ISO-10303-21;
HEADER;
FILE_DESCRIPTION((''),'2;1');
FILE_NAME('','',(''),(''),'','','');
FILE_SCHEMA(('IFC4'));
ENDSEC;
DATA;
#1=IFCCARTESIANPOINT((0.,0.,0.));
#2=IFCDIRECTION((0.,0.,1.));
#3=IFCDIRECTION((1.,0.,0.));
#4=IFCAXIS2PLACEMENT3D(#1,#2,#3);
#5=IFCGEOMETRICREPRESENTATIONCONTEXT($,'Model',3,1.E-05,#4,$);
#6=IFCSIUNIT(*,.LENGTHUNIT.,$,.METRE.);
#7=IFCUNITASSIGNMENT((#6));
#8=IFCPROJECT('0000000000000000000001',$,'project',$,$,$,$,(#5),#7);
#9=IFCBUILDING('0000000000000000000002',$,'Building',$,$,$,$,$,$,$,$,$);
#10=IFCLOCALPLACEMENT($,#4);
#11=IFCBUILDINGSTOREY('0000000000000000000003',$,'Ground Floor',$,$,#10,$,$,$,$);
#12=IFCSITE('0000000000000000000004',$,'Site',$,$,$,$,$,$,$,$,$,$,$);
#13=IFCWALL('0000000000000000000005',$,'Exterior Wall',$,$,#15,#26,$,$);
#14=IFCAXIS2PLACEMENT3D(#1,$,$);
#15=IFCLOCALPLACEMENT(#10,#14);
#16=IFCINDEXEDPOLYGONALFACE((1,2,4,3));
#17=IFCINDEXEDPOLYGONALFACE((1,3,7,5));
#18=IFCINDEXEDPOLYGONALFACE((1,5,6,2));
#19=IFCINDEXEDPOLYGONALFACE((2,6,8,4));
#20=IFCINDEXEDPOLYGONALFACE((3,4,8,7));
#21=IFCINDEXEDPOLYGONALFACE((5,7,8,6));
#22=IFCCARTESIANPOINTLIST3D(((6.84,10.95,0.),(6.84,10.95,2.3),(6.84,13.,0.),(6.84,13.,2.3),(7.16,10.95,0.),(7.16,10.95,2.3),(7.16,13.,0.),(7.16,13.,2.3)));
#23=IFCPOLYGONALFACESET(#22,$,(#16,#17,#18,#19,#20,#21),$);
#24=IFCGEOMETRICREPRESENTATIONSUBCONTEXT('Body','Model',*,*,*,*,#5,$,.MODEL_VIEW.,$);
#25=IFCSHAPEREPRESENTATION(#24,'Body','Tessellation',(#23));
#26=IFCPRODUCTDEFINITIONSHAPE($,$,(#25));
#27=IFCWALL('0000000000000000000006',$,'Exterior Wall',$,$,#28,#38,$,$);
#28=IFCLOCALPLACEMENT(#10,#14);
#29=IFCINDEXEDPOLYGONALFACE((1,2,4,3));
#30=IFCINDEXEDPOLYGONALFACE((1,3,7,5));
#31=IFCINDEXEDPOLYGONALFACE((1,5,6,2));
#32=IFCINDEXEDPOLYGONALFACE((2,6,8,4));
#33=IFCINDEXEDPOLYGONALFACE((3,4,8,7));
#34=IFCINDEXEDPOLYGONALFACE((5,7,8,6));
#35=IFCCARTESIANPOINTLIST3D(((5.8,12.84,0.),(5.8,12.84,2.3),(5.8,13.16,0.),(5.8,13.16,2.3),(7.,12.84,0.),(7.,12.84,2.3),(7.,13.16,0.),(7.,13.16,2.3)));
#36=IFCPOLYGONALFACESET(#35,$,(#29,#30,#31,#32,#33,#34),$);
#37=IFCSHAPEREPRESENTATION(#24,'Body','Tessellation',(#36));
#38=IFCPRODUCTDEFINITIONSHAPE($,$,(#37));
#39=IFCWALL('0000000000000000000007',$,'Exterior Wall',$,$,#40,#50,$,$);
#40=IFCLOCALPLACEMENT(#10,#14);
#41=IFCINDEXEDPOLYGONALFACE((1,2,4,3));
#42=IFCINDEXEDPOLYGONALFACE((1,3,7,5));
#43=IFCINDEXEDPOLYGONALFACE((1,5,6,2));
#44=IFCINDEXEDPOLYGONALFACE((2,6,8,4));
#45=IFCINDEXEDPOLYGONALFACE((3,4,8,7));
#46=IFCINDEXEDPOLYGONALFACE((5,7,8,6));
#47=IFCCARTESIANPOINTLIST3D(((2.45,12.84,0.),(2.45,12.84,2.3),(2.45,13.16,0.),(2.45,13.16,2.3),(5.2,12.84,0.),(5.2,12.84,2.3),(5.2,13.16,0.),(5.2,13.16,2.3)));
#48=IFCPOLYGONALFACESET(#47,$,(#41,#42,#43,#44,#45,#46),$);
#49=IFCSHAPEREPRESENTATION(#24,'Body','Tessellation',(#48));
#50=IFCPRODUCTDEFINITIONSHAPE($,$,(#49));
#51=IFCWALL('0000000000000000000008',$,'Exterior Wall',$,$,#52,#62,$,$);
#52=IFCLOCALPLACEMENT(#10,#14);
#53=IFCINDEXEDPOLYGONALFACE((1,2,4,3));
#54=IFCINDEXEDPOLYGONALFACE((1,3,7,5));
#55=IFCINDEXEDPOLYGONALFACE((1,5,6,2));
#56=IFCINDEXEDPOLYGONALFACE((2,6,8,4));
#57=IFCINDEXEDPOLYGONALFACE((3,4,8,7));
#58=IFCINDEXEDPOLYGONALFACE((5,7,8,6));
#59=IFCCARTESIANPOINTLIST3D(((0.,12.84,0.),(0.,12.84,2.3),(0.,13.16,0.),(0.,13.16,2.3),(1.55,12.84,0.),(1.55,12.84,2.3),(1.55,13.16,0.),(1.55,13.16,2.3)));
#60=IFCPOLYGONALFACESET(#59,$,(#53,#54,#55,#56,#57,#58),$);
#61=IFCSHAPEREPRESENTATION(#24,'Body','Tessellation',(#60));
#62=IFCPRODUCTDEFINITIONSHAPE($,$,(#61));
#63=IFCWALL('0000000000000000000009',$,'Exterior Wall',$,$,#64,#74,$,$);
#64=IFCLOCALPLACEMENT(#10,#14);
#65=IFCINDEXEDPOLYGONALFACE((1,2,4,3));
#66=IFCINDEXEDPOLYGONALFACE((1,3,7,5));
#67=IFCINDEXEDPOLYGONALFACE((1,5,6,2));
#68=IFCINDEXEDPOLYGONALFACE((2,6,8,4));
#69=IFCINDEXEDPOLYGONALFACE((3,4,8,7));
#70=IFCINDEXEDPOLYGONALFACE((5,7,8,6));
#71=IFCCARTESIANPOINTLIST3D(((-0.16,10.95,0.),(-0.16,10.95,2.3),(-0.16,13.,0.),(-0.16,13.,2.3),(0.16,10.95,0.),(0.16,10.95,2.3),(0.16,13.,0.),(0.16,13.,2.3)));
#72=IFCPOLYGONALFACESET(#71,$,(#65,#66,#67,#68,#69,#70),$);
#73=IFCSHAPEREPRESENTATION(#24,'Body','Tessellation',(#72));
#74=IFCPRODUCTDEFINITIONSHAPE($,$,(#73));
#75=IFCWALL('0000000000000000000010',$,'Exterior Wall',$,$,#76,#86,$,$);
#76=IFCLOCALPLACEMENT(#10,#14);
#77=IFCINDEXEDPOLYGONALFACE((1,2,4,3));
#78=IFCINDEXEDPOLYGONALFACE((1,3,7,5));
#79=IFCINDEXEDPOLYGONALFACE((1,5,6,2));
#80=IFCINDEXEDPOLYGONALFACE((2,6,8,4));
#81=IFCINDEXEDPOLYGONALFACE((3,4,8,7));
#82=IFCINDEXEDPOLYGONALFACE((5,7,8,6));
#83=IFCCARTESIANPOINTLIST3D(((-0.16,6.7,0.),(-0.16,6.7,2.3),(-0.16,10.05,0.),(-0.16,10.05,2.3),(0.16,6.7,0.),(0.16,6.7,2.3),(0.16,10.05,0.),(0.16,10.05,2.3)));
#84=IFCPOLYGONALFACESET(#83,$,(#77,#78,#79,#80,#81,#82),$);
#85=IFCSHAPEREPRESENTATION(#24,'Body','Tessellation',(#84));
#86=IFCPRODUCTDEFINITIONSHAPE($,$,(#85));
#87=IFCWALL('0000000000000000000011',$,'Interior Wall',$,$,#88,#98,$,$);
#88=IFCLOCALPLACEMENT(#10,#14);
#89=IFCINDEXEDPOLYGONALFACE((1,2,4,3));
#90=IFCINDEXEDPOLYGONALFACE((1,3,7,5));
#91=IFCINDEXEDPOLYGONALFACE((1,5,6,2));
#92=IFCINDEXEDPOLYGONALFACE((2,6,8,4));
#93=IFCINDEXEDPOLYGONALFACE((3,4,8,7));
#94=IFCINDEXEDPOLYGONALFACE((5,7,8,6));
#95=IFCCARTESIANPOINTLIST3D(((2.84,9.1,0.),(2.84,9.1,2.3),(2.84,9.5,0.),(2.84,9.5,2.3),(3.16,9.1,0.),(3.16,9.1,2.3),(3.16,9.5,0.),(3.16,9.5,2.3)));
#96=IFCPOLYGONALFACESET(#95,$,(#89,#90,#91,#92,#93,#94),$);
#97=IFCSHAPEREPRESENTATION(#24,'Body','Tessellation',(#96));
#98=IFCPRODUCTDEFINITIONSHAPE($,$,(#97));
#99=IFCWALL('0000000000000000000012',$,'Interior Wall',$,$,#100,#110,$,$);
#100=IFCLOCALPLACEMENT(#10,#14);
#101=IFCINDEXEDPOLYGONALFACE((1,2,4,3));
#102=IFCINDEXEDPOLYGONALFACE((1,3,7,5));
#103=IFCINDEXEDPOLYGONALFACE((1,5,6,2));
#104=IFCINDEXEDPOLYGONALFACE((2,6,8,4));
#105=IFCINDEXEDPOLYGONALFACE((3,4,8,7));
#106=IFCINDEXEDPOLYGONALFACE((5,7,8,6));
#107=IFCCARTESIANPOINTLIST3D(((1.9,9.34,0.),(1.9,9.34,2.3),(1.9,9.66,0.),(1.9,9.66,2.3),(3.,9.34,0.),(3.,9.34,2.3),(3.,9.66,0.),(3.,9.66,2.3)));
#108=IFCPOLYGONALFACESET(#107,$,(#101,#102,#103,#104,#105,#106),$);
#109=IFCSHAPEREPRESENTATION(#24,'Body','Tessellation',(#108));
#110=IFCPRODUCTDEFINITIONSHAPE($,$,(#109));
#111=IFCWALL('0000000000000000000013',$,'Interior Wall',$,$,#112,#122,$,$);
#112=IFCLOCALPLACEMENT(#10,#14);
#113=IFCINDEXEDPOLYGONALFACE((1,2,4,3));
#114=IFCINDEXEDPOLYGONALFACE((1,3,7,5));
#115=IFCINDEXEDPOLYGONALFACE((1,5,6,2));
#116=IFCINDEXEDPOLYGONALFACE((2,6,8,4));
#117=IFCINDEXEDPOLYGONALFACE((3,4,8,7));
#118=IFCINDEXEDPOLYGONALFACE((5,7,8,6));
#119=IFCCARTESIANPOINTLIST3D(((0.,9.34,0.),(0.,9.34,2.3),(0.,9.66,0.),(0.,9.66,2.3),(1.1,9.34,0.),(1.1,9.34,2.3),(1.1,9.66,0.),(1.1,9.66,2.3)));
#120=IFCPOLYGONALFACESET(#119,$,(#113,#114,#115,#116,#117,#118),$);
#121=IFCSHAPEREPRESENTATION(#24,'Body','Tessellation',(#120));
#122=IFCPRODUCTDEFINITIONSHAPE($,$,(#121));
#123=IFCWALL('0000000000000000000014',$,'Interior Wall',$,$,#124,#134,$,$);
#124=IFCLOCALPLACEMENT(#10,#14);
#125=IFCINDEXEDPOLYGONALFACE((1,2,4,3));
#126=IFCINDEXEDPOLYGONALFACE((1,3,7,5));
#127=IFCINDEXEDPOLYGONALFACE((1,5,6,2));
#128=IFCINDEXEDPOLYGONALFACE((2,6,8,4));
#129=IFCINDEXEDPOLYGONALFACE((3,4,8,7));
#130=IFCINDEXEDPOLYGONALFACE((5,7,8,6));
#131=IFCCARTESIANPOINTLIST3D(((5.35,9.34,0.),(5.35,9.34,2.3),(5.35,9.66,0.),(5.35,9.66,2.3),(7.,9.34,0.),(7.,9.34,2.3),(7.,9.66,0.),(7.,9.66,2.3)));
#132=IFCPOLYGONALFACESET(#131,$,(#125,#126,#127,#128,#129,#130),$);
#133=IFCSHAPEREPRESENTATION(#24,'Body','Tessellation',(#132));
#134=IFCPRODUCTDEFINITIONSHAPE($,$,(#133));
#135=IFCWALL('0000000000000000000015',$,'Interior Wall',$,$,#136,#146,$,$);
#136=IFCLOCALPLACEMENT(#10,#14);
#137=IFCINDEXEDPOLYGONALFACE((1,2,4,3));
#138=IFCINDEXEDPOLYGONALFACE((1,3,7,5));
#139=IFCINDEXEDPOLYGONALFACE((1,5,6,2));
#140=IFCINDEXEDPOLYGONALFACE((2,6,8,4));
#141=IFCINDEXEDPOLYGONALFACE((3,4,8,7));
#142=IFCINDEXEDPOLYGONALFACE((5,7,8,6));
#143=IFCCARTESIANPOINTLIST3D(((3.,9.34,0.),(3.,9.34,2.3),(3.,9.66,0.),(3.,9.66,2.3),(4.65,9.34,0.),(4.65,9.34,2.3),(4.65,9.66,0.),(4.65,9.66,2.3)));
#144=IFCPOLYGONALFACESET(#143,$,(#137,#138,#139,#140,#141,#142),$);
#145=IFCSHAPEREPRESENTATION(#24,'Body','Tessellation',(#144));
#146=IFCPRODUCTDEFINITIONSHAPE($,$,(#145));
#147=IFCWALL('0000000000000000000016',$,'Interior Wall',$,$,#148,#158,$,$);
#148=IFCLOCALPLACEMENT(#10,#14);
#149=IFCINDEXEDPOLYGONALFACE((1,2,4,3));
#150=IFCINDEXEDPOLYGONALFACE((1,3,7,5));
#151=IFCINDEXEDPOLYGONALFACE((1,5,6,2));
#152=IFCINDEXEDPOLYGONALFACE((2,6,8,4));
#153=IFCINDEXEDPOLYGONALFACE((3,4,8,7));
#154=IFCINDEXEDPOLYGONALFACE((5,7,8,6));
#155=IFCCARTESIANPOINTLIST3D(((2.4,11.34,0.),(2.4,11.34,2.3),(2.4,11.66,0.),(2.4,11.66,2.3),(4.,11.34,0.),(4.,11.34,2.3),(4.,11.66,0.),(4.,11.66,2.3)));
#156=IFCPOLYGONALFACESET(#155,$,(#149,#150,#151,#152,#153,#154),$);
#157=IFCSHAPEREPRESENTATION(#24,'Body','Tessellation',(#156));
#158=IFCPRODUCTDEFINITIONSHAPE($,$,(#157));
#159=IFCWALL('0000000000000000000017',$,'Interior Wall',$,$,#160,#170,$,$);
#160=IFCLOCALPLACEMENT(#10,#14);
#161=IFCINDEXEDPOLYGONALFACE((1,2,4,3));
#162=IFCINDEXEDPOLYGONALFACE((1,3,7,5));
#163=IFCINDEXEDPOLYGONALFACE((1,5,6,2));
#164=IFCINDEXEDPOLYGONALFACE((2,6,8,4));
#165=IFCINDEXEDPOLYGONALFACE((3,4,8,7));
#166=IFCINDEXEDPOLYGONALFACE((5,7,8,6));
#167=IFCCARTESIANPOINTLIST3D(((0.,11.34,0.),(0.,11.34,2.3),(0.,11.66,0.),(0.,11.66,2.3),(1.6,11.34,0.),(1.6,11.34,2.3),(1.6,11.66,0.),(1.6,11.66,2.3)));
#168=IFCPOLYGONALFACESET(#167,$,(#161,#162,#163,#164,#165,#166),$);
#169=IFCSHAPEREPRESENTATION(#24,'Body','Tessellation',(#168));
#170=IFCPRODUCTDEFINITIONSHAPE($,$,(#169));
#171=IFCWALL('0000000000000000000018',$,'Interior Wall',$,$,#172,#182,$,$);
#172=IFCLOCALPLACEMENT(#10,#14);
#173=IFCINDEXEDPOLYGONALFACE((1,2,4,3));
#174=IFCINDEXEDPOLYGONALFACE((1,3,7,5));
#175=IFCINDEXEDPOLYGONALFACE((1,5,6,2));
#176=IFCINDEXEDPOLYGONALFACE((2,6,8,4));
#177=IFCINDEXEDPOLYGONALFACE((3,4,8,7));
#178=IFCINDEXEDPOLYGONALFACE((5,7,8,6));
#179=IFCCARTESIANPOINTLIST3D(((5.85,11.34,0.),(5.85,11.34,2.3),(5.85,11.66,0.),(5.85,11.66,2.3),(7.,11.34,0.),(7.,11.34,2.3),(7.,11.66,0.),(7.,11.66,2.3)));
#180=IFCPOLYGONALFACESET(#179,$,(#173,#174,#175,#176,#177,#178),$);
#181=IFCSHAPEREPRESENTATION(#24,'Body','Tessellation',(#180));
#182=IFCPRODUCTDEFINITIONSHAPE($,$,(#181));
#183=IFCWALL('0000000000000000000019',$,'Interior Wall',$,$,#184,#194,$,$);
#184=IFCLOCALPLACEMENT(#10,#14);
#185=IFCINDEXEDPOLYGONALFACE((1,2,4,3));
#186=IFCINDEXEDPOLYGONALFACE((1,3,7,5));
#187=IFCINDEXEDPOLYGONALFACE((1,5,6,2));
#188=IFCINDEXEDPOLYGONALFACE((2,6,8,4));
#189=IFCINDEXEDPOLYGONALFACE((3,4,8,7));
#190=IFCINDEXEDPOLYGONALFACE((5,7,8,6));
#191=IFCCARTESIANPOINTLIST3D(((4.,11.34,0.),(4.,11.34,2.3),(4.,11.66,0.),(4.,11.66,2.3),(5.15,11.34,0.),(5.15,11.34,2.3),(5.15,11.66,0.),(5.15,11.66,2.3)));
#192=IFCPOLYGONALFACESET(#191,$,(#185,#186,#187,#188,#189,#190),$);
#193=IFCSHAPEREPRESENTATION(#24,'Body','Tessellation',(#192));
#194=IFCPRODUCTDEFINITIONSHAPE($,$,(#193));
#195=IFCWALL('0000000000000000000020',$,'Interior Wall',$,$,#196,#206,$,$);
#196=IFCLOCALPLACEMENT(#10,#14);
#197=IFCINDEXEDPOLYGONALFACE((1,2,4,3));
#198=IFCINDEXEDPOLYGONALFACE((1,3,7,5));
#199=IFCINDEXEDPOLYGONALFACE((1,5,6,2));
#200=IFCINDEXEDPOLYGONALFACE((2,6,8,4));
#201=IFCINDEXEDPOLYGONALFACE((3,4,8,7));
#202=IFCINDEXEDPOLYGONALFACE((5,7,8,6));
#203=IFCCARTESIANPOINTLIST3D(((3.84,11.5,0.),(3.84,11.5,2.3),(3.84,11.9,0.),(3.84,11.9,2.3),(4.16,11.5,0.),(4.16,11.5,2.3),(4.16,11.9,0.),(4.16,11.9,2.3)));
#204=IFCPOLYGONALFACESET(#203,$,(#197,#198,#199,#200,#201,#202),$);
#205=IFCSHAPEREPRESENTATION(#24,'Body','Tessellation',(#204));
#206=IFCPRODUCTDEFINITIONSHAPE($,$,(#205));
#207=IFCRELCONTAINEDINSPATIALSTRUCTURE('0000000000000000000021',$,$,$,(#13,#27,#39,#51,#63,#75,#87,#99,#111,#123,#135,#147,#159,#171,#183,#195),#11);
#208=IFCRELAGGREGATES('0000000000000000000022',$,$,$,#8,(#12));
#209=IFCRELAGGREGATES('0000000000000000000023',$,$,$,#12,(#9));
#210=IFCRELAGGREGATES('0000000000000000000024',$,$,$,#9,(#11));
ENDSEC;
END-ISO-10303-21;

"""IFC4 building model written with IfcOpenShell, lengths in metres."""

from ifc_helpers import new_model, si_unit, frame, origin_with_axes, place, context, subcontext, project, spatial, indexed_curve, outline, extrude, element, save


model = new_model("IFC4")

# Units and contexts
model_context = context("Model", 3, precision=1e-05, world=origin_with_axes())
body_context = subcontext(model_context, "Body", "Model", "MODEL_VIEW")
ifc_project = project(units=[si_unit("LENGTHUNIT", "METRE")], contexts=[model_context])

# Site, building, storey
site = spatial("IfcSite", under=ifc_project, Name="Site")
building = spatial("IfcBuilding", under=site, Name="Building")
storey_placement = place(None, origin_with_axes())
storey = spatial("IfcBuildingStorey", under=building, at=storey_placement, Name="Ground Floor")

# Walls
wall_1_placement = place(storey_placement, frame((7.0, 10.95, 0.0), z_axis=(0.0, 0.0, 1.0), x_axis=(0.0, 1.0, 0.0)))
element("IfcWall", 1, at=wall_1_placement, inside=storey, Name="Exterior Wall", context=body_context, shape_type="SweptSolid", body=[
    extrude(outline(indexed_curve([(0.0, 0.0), (0.0, 0.32), (2.05, 0.32), (2.05, 0.0), (0.0, 0.0)], self_intersect=False)), frame((0.0, -0.16, 0.0), z_axis=(0.0, 0.0, 1.0), x_axis=(1.0, 0.0, 0.0)), (0.0, 0.0, 1.0), 2.3),
])
wall_2_placement = place(storey_placement, frame((7.0, 13.0, 0.0), z_axis=(0.0, 0.0, 1.0), x_axis=(-1.0, 0.0, 0.0)))
element("IfcWall", 2, at=wall_2_placement, inside=storey, Name="Exterior Wall", context=body_context, shape_type="SweptSolid", body=[
    extrude(outline(indexed_curve([(0.0, 0.0), (0.0, 0.32), (1.2, 0.32), (1.2, 0.0), (0.0, 0.0)], self_intersect=False)), frame((0.0, -0.16, 0.0), z_axis=(0.0, 0.0, 1.0), x_axis=(1.0, 0.0, 0.0)), (0.0, 0.0, 1.0), 2.3),
])
wall_3_placement = place(storey_placement, frame((5.2, 13.0, 0.0), z_axis=(0.0, 0.0, 1.0), x_axis=(-1.0, 0.0, 0.0)))
element("IfcWall", 3, at=wall_3_placement, inside=storey, Name="Exterior Wall", context=body_context, shape_type="SweptSolid", body=[
    extrude(outline(indexed_curve([(0.0, 0.0), (0.0, 0.32), (2.75, 0.32), (2.75, 0.0), (0.0, 0.0)], self_intersect=False)), frame((0.0, -0.16, 0.0), z_axis=(0.0, 0.0, 1.0), x_axis=(1.0, 0.0, 0.0)), (0.0, 0.0, 1.0), 2.3),
])
wall_4_placement = place(storey_placement, frame((1.55, 13.0, 0.0), z_axis=(0.0, 0.0, 1.0), x_axis=(-1.0, 0.0, 0.0)))
element("IfcWall", 4, at=wall_4_placement, inside=storey, Name="Exterior Wall", context=body_context, shape_type="SweptSolid", body=[
    extrude(outline(indexed_curve([(0.0, 0.0), (0.0, 0.32), (1.55, 0.32), (1.55, 0.0), (0.0, 0.0)], self_intersect=False)), frame((0.0, -0.16, 0.0), z_axis=(0.0, 0.0, 1.0), x_axis=(1.0, 0.0, 0.0)), (0.0, 0.0, 1.0), 2.3),
])
wall_5_placement = place(storey_placement, frame((0.0, 13.0, 0.0), z_axis=(0.0, 0.0, 1.0), x_axis=(0.0, -1.0, 0.0)))
element("IfcWall", 5, at=wall_5_placement, inside=storey, Name="Exterior Wall", context=body_context, shape_type="SweptSolid", body=[
    extrude(outline(indexed_curve([(0.0, 0.0), (0.0, 0.32), (2.05, 0.32), (2.05, 0.0), (0.0, 0.0)], self_intersect=False)), frame((0.0, -0.16, 0.0), z_axis=(0.0, 0.0, 1.0), x_axis=(1.0, 0.0, 0.0)), (0.0, 0.0, 1.0), 2.3),
])
wall_6_placement = place(storey_placement, frame((0.0, 10.05, 0.0), z_axis=(0.0, 0.0, 1.0), x_axis=(0.0, -1.0, 0.0)))
element("IfcWall", 6, at=wall_6_placement, inside=storey, Name="Exterior Wall", context=body_context, shape_type="SweptSolid", body=[
    extrude(outline(indexed_curve([(0.0, 0.0), (0.0, 0.32), (3.35, 0.32), (3.35, 0.0), (0.0, 0.0)], self_intersect=False)), frame((0.0, -0.16, 0.0), z_axis=(0.0, 0.0, 1.0), x_axis=(1.0, 0.0, 0.0)), (0.0, 0.0, 1.0), 2.3),
])
wall_7_placement = place(storey_placement, frame((3.0, 9.1, 0.0), z_axis=(0.0, 0.0, 1.0), x_axis=(0.0, 1.0, 0.0)))
element("IfcWall", 7, at=wall_7_placement, inside=storey, Name="Interior Wall", context=body_context, shape_type="SweptSolid", body=[
    extrude(outline(indexed_curve([(0.0, 0.0), (0.0, 0.32), (0.4, 0.32), (0.4, 0.0), (0.0, 0.0)], self_intersect=False)), frame((0.0, -0.16, 0.0), z_axis=(0.0, 0.0, 1.0), x_axis=(1.0, 0.0, 0.0)), (0.0, 0.0, 1.0), 2.3),
])
for number, where, z_axis, x_axis, name in (
    (8, (3.0, 9.5, 0.0), (0.0, 0.0, 1.0), (-1.0, 0.0, 0.0), "Interior Wall"),
    (9, (1.1, 9.5, 0.0), (0.0, 0.0, 1.0), (-1.0, 0.0, 0.0), "Interior Wall"),
):
    element("IfcWall", number, at=place(storey_placement, frame(where, z_axis=z_axis, x_axis=x_axis)), inside=storey, Name=name, context=body_context, shape_type="SweptSolid", body=[
        extrude(outline(indexed_curve([(0.0, 0.0), (0.0, 0.32), (1.1, 0.32), (1.1, 0.0), (0.0, 0.0)], self_intersect=False)), frame((0.0, -0.16, 0.0), z_axis=(0.0, 0.0, 1.0), x_axis=(1.0, 0.0, 0.0)), (0.0, 0.0, 1.0), 2.3),
    ])
for number, where, z_axis, x_axis, name in (
    (10, (7.0, 9.5, 0.0), (0.0, 0.0, 1.0), (-1.0, 0.0, 0.0), "Interior Wall"),
    (11, (4.65, 9.5, 0.0), (0.0, 0.0, 1.0), (-1.0, 0.0, 0.0), "Interior Wall"),
):
    element("IfcWall", number, at=place(storey_placement, frame(where, z_axis=z_axis, x_axis=x_axis)), inside=storey, Name=name, context=body_context, shape_type="SweptSolid", body=[
        extrude(outline(indexed_curve([(0.0, 0.0), (0.0, 0.32), (1.65, 0.32), (1.65, 0.0), (0.0, 0.0)], self_intersect=False)), frame((0.0, -0.16, 0.0), z_axis=(0.0, 0.0, 1.0), x_axis=(1.0, 0.0, 0.0)), (0.0, 0.0, 1.0), 2.3),
    ])
for number, where, z_axis, x_axis, name in (
    (12, (4.0, 11.5, 0.0), (0.0, 0.0, 1.0), (-1.0, 0.0, 0.0), "Interior Wall"),
    (13, (1.6, 11.5, 0.0), (0.0, 0.0, 1.0), (-1.0, 0.0, 0.0), "Interior Wall"),
):
    element("IfcWall", number, at=place(storey_placement, frame(where, z_axis=z_axis, x_axis=x_axis)), inside=storey, Name=name, context=body_context, shape_type="SweptSolid", body=[
        extrude(outline(indexed_curve([(0.0, 0.0), (0.0, 0.32), (1.6, 0.32), (1.6, 0.0), (0.0, 0.0)], self_intersect=False)), frame((0.0, -0.16, 0.0), z_axis=(0.0, 0.0, 1.0), x_axis=(1.0, 0.0, 0.0)), (0.0, 0.0, 1.0), 2.3),
    ])
for number, where, z_axis, x_axis, name in (
    (14, (7.0, 11.5, 0.0), (0.0, 0.0, 1.0), (-1.0, 0.0, 0.0), "Interior Wall"),
    (15, (5.15, 11.5, 0.0), (0.0, 0.0, 1.0), (-1.0, 0.0, 0.0), "Interior Wall"),
):
    element("IfcWall", number, at=place(storey_placement, frame(where, z_axis=z_axis, x_axis=x_axis)), inside=storey, Name=name, context=body_context, shape_type="SweptSolid", body=[
        extrude(outline(indexed_curve([(0.0, 0.0), (0.0, 0.32), (1.15, 0.32), (1.15, 0.0), (0.0, 0.0)], self_intersect=False)), frame((0.0, -0.16, 0.0), z_axis=(0.0, 0.0, 1.0), x_axis=(1.0, 0.0, 0.0)), (0.0, 0.0, 1.0), 2.3),
    ])
for number, where, z_axis, x_axis, name in (
    (16, (4.0, 11.5, 0.0), (0.0, 0.0, 1.0), (0.0, 1.0, 0.0), "Interior Wall"),
):
    element("IfcWall", number, at=place(storey_placement, frame(where, z_axis=z_axis, x_axis=x_axis)), inside=storey, Name=name, context=body_context, shape_type="SweptSolid", body=[
        extrude(outline(indexed_curve([(0.0, 0.0), (0.0, 0.32), (0.4, 0.32), (0.4, 0.0), (0.0, 0.0)], self_intersect=False)), frame((0.0, -0.16, 0.0), z_axis=(0.0, 0.0, 1.0), x_axis=(1.0, 0.0, 0.0)), (0.0, 0.0, 1.0), 2.3),
    ])

save(model, "model.ifc")
